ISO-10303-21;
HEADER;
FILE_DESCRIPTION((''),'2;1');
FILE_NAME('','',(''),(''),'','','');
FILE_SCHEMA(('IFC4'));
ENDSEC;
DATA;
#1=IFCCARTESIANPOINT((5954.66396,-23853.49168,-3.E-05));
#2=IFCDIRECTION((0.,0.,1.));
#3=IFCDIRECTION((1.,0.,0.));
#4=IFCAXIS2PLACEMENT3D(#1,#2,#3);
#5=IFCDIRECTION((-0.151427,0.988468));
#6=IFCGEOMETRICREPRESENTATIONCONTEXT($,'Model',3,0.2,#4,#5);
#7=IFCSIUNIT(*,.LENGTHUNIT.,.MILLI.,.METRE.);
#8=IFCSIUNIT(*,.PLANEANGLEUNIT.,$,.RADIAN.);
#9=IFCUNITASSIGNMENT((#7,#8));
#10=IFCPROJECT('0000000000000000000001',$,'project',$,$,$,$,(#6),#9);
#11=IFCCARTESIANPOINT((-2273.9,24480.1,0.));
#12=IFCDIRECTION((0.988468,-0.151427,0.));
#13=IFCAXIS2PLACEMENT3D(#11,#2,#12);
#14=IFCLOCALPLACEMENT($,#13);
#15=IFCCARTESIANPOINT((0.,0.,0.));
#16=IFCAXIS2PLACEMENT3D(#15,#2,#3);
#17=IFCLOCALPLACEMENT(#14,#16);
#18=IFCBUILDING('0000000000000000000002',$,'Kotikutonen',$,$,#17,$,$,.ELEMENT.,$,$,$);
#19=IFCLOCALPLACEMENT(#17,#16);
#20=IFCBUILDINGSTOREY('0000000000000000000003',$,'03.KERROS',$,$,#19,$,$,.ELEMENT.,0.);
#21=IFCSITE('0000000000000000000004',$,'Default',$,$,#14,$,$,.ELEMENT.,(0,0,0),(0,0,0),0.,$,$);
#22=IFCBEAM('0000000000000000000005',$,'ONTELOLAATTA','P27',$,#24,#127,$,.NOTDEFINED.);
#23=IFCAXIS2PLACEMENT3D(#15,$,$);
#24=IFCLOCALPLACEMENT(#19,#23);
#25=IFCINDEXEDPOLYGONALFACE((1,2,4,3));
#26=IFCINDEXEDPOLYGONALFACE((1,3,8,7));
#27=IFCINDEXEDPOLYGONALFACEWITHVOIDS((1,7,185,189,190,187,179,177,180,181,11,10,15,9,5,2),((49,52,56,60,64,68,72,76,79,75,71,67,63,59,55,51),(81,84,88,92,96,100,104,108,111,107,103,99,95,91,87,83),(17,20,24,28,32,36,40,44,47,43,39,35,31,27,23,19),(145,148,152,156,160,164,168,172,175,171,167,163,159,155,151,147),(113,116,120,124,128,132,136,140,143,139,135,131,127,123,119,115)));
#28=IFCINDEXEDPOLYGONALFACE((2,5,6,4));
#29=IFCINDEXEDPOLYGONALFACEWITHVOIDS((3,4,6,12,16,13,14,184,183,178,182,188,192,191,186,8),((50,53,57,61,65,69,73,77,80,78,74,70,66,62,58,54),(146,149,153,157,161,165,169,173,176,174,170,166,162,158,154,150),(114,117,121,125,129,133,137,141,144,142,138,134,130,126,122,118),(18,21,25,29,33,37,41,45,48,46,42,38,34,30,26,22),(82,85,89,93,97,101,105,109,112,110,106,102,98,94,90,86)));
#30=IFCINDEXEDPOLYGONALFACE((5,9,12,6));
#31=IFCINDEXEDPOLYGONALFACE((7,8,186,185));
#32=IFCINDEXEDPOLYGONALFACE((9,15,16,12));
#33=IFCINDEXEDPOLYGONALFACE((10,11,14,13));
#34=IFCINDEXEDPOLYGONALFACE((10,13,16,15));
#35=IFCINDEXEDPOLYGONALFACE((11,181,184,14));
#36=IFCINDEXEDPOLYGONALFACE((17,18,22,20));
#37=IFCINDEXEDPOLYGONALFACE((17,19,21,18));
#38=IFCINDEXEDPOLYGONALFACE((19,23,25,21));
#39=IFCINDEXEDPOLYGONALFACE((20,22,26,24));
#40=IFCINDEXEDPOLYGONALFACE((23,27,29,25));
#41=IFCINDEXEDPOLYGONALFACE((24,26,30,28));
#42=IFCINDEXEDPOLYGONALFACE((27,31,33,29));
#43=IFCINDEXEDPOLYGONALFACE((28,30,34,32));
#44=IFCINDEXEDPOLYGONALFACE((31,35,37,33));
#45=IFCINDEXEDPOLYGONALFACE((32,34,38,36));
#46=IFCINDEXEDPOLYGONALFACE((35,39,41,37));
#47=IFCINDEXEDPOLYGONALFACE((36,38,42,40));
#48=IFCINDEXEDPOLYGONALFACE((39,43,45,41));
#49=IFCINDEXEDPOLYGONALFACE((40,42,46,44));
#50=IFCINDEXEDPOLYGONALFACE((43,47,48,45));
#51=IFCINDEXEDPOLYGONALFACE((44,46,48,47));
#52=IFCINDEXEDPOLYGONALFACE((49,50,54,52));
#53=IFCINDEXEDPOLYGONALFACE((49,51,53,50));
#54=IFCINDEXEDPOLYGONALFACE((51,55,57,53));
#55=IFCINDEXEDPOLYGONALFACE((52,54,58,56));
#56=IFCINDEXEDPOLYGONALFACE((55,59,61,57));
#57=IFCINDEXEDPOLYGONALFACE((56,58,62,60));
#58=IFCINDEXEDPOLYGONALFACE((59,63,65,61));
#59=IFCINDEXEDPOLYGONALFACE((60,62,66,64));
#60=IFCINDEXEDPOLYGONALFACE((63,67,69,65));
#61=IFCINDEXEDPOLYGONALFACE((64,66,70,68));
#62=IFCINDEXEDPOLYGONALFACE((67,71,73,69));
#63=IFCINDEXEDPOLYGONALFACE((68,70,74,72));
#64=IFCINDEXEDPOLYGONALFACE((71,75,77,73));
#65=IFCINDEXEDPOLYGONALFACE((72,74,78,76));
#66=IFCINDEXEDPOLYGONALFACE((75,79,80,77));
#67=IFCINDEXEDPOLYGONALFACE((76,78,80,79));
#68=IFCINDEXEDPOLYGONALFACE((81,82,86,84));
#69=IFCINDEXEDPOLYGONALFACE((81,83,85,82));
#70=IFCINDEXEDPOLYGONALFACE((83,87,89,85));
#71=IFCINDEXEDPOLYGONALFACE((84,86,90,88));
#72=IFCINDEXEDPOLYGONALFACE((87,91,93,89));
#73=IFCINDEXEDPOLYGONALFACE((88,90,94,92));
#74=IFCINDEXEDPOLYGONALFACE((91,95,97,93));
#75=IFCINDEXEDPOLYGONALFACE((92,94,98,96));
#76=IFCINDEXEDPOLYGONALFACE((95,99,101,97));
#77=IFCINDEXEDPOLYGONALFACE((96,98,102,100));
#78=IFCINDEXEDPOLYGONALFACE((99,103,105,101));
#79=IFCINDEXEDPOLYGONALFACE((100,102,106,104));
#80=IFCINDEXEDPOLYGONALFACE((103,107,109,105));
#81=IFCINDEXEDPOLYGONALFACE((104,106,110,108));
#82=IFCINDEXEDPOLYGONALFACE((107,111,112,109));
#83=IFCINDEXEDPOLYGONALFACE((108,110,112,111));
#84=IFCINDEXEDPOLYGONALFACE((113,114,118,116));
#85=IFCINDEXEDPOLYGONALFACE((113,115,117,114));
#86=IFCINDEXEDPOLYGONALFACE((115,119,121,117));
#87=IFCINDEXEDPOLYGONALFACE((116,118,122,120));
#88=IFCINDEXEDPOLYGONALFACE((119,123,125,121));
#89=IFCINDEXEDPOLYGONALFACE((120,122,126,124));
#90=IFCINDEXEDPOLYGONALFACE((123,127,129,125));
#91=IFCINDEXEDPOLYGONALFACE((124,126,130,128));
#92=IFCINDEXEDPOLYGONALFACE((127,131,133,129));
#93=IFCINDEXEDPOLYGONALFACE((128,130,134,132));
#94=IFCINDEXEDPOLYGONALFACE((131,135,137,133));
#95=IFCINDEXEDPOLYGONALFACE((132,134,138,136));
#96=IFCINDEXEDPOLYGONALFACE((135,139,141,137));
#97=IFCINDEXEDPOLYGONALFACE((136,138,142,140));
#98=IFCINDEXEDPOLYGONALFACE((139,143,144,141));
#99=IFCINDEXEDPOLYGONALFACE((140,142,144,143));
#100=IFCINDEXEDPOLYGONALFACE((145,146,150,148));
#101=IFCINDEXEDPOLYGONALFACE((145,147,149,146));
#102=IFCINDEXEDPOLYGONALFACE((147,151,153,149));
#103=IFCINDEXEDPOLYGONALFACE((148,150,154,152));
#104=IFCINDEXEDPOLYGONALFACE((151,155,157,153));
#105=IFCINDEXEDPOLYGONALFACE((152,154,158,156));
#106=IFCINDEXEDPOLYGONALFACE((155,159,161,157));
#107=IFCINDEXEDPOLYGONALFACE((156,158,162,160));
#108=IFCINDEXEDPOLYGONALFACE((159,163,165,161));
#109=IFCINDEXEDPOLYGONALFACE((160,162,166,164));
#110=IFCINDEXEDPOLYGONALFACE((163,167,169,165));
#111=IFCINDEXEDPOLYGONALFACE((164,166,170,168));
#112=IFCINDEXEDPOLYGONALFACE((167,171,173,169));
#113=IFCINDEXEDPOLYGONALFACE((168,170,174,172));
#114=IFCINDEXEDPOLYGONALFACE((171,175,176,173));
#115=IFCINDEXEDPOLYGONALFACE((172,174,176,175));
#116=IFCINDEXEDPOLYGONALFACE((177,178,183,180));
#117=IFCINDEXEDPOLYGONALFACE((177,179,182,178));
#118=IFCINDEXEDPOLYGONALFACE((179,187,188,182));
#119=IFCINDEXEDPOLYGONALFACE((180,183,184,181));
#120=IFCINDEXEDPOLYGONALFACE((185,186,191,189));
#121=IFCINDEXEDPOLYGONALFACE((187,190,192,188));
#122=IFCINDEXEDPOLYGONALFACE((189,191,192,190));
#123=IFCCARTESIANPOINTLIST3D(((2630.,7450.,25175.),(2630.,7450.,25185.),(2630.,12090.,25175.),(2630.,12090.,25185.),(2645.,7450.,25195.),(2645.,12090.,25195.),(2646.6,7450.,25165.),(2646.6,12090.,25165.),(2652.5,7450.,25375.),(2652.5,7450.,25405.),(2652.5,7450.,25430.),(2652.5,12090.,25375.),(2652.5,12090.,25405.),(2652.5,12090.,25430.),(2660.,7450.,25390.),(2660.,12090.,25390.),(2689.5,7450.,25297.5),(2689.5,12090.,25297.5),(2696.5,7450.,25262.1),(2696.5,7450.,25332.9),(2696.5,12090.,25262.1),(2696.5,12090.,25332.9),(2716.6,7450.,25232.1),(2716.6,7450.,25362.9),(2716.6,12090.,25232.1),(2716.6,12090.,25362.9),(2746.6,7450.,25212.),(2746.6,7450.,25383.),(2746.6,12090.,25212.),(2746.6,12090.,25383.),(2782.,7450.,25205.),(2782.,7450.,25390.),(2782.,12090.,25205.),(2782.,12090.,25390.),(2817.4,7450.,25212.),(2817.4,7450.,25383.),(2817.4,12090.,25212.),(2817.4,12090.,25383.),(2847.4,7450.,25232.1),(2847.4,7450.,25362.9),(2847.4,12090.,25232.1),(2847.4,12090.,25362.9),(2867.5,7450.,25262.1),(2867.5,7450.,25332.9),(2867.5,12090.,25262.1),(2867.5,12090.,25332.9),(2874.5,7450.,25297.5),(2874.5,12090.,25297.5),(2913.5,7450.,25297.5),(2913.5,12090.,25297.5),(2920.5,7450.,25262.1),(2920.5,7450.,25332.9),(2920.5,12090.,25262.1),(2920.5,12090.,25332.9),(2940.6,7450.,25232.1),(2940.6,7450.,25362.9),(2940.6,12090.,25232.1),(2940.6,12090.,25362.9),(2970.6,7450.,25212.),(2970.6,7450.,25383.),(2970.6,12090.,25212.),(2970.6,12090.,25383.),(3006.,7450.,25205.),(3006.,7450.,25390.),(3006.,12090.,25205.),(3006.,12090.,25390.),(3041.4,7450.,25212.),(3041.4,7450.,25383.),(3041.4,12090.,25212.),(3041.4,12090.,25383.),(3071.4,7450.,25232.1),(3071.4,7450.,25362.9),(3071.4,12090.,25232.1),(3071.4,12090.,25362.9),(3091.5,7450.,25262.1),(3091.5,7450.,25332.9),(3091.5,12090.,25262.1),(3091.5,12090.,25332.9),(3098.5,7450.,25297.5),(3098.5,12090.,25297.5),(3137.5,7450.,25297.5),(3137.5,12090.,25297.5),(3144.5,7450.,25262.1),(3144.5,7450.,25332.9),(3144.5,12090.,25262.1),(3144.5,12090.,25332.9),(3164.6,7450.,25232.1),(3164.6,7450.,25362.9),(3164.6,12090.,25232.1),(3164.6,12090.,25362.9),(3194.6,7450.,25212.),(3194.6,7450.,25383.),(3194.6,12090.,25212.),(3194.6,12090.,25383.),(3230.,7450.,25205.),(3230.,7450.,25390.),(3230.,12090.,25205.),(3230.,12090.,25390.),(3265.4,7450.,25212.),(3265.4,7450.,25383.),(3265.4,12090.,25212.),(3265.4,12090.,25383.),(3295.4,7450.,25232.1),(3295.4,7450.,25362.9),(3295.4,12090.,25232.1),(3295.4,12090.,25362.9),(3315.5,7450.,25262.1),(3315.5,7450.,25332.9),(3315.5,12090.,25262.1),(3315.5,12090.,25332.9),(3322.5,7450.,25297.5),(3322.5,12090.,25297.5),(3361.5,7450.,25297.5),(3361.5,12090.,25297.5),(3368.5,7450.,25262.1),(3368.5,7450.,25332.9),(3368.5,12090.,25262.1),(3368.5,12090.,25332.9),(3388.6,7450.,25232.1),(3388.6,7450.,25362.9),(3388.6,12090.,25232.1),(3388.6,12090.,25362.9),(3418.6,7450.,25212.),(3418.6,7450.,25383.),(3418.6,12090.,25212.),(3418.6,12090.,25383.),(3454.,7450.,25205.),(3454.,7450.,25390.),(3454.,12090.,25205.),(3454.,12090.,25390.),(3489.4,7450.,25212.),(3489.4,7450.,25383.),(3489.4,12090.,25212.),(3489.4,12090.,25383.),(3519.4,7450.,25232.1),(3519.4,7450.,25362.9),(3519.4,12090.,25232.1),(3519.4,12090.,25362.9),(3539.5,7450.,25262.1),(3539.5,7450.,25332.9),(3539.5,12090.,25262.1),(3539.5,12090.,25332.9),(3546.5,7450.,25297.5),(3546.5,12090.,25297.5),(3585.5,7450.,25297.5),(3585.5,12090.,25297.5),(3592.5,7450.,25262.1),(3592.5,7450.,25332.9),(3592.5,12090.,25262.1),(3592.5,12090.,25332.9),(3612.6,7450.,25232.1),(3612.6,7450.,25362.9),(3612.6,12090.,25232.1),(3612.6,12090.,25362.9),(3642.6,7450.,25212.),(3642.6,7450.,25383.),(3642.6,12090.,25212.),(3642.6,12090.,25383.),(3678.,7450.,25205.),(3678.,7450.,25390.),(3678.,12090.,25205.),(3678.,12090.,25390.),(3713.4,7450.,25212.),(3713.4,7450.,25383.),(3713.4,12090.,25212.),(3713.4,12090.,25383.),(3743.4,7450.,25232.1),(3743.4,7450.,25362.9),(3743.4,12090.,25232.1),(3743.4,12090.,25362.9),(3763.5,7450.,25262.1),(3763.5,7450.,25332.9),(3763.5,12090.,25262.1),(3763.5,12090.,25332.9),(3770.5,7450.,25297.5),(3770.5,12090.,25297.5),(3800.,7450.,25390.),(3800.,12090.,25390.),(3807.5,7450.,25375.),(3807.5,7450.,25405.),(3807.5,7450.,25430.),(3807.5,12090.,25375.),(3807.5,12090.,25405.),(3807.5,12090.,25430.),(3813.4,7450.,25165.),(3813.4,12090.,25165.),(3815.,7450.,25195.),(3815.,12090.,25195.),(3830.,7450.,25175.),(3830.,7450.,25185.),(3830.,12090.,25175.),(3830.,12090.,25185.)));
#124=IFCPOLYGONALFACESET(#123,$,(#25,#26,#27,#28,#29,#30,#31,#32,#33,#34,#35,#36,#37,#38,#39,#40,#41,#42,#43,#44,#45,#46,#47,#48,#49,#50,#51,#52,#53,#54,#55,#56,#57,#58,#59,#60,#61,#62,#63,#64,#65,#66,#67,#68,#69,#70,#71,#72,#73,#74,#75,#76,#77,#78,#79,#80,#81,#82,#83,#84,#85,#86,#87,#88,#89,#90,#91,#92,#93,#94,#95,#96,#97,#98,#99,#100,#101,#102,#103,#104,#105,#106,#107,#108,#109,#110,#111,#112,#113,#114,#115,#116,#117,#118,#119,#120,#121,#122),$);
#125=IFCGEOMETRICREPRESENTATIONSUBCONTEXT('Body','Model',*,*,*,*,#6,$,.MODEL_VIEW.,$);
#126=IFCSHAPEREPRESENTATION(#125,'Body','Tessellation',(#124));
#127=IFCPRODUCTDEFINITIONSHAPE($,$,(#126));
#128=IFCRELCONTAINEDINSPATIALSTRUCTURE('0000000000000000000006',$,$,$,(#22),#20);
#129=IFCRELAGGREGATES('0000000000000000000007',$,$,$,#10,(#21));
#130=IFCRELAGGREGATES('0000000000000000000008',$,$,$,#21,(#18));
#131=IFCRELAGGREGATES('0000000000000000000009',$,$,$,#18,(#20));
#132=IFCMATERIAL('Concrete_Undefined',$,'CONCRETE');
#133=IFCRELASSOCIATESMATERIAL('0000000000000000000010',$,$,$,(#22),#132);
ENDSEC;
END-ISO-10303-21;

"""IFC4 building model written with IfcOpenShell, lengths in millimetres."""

from ifc_helpers import new_model, si_unit, direction, frame, origin_with_axes, place, context, subcontext, project, spatial, line, indexed_curve, outline, extrude, material, element, save


model = new_model("IFC4")

# Units and contexts
model_context = context("Model", 3, precision=0.2, world=frame((5954.66396, -23853.49168, -3e-05), z_axis=(0.0, 0.0, 1.0), x_axis=(1.0, 0.0, 0.0)), true_north=direction((-0.151427, 0.988468)))
body_context = subcontext(model_context, "Body", "Model", "MODEL_VIEW")
ifc_project = project(units=[si_unit("LENGTHUNIT", "METRE", prefix="MILLI"), si_unit("PLANEANGLEUNIT", "RADIAN")], contexts=[model_context])

# Site, building, storey
site_placement = place(None, frame((-2273.9, 24480.1, 0.0), z_axis=(0.0, 0.0, 1.0), x_axis=(0.988468, -0.151427, 0.0)))
site = spatial("IfcSite", under=ifc_project, at=site_placement, Name="Default", CompositionType="ELEMENT", RefLatitude=(0, 0, 0), RefLongitude=(0, 0, 0), RefElevation=0.0)
building_placement = place(site_placement, origin_with_axes())
building = spatial("IfcBuilding", under=site, at=building_placement, Name="Kotikutonen", CompositionType="ELEMENT")
storey_placement = place(building_placement, origin_with_axes())
storey = spatial("IfcBuildingStorey", under=building, at=storey_placement, Name="03.KERROS", CompositionType="ELEMENT", Elevation=0.0)

# Shared definitions
ifc_material_1 = material(Name="Concrete_Undefined", Category="CONCRETE")

# Beam
beam_1_placement = place(storey_placement, frame((3230.0, 12090.0, 25297.5), z_axis=(-1.0, 0.0, 0.0), x_axis=(0.0, -1.0, 0.0)))
element("IfcBeam", 1, at=beam_1_placement, inside=storey, material=ifc_material_1, Name="ONTELOLAATTA", Description="P27", PredefinedType="NOTDEFINED", context=body_context, shape_type="SolidModel", body=[
    extrude(outline(indexed_curve([(-600.0, -122.5), (-583.4, -132.5), (583.4, -132.5), (600.0, -122.5), (600.0, -112.5), (585.0, -102.5), (577.5, 77.5), (570.0, 92.5), (577.5, 107.5), (577.5, 132.5), (-577.5, 132.5), (-577.5, 107.5), (-570.0, 92.5), (-577.5, 77.5), (-585.0, -102.5), (-600.0, -112.5)], segments=[line(1, 2, 3, 4, 5, 6, 7, 8, 9, 10, 11, 12, 13, 14, 15, 16, 1)]), holes=[indexed_curve([(-448.0, -92.5), (-483.4, -85.5), (-513.4, -65.4), (-533.5, -35.4), (-540.5, 0.0), (-533.5, 35.4), (-513.4, 65.4), (-483.4, 85.5), (-448.0, 92.5), (-412.6, 85.5), (-382.6, 65.4), (-362.5, 35.4), (-355.5, 0.0), (-362.5, -35.4), (-382.6, -65.4), (-412.6, -85.5)], segments=[line(1, 2, 3, 4, 5, 6, 7, 8, 9, 10, 11, 12, 13, 14, 15, 16, 1)]), indexed_curve([(-224.0, -92.5), (-259.4, -85.5), (-289.4, -65.4), (-309.5, -35.4), (-316.5, 0.0), (-309.5, 35.4), (-289.4, 65.4), (-259.4, 85.5), (-224.0, 92.5), (-188.6, 85.5), (-158.6, 65.4), (-138.5, 35.4), (-131.5, 0.0), (-138.5, -35.4), (-158.6, -65.4), (-188.6, -85.5)], segments=[line(1, 2, 3, 4, 5, 6, 7, 8, 9, 10, 11, 12, 13, 14, 15, 16, 1)]), indexed_curve([(0.0, -92.5), (-35.4, -85.5), (-65.4, -65.4), (-85.5, -35.4), (-92.5, 0.0), (-85.5, 35.4), (-65.4, 65.4), (-35.4, 85.5), (0.0, 92.5), (35.4, 85.5), (65.4, 65.4), (85.5, 35.4), (92.5, 0.0), (85.5, -35.4), (65.4, -65.4), (35.4, -85.5)], segments=[line(1, 2, 3, 4, 5, 6, 7, 8, 9, 10, 11, 12, 13, 14, 15, 16, 1)]), indexed_curve([(224.0, -92.5), (188.6, -85.5), (158.6, -65.4), (138.5, -35.4), (131.5, 0.0), (138.5, 35.4), (158.6, 65.4), (188.6, 85.5), (224.0, 92.5), (259.4, 85.5), (289.4, 65.4), (309.5, 35.4), (316.5, 0.0), (309.5, -35.4), (289.4, -65.4), (259.4, -85.5)], segments=[line(1, 2, 3, 4, 5, 6, 7, 8, 9, 10, 11, 12, 13, 14, 15, 16, 1)]), indexed_curve([(448.0, -92.5), (412.6, -85.5), (382.6, -65.4), (362.5, -35.4), (355.5, 0.0), (362.5, 35.4), (382.6, 65.4), (412.6, 85.5), (448.0, 92.5), (483.4, 85.5), (513.4, 65.4), (533.5, 35.4), (540.5, 0.0), (533.5, -35.4), (513.4, -65.4), (483.4, -85.5)], segments=[line(1, 2, 3, 4, 5, 6, 7, 8, 9, 10, 11, 12, 13, 14, 15, 16, 1)])]), frame((0.0, 0.0, 0.0), z_axis=(-1.0, 0.0, 0.0), x_axis=(0.0, 0.0, 1.0)), (0.0, 0.0, -1.0), 4640.0),
])

save(model, "model.ifc")
